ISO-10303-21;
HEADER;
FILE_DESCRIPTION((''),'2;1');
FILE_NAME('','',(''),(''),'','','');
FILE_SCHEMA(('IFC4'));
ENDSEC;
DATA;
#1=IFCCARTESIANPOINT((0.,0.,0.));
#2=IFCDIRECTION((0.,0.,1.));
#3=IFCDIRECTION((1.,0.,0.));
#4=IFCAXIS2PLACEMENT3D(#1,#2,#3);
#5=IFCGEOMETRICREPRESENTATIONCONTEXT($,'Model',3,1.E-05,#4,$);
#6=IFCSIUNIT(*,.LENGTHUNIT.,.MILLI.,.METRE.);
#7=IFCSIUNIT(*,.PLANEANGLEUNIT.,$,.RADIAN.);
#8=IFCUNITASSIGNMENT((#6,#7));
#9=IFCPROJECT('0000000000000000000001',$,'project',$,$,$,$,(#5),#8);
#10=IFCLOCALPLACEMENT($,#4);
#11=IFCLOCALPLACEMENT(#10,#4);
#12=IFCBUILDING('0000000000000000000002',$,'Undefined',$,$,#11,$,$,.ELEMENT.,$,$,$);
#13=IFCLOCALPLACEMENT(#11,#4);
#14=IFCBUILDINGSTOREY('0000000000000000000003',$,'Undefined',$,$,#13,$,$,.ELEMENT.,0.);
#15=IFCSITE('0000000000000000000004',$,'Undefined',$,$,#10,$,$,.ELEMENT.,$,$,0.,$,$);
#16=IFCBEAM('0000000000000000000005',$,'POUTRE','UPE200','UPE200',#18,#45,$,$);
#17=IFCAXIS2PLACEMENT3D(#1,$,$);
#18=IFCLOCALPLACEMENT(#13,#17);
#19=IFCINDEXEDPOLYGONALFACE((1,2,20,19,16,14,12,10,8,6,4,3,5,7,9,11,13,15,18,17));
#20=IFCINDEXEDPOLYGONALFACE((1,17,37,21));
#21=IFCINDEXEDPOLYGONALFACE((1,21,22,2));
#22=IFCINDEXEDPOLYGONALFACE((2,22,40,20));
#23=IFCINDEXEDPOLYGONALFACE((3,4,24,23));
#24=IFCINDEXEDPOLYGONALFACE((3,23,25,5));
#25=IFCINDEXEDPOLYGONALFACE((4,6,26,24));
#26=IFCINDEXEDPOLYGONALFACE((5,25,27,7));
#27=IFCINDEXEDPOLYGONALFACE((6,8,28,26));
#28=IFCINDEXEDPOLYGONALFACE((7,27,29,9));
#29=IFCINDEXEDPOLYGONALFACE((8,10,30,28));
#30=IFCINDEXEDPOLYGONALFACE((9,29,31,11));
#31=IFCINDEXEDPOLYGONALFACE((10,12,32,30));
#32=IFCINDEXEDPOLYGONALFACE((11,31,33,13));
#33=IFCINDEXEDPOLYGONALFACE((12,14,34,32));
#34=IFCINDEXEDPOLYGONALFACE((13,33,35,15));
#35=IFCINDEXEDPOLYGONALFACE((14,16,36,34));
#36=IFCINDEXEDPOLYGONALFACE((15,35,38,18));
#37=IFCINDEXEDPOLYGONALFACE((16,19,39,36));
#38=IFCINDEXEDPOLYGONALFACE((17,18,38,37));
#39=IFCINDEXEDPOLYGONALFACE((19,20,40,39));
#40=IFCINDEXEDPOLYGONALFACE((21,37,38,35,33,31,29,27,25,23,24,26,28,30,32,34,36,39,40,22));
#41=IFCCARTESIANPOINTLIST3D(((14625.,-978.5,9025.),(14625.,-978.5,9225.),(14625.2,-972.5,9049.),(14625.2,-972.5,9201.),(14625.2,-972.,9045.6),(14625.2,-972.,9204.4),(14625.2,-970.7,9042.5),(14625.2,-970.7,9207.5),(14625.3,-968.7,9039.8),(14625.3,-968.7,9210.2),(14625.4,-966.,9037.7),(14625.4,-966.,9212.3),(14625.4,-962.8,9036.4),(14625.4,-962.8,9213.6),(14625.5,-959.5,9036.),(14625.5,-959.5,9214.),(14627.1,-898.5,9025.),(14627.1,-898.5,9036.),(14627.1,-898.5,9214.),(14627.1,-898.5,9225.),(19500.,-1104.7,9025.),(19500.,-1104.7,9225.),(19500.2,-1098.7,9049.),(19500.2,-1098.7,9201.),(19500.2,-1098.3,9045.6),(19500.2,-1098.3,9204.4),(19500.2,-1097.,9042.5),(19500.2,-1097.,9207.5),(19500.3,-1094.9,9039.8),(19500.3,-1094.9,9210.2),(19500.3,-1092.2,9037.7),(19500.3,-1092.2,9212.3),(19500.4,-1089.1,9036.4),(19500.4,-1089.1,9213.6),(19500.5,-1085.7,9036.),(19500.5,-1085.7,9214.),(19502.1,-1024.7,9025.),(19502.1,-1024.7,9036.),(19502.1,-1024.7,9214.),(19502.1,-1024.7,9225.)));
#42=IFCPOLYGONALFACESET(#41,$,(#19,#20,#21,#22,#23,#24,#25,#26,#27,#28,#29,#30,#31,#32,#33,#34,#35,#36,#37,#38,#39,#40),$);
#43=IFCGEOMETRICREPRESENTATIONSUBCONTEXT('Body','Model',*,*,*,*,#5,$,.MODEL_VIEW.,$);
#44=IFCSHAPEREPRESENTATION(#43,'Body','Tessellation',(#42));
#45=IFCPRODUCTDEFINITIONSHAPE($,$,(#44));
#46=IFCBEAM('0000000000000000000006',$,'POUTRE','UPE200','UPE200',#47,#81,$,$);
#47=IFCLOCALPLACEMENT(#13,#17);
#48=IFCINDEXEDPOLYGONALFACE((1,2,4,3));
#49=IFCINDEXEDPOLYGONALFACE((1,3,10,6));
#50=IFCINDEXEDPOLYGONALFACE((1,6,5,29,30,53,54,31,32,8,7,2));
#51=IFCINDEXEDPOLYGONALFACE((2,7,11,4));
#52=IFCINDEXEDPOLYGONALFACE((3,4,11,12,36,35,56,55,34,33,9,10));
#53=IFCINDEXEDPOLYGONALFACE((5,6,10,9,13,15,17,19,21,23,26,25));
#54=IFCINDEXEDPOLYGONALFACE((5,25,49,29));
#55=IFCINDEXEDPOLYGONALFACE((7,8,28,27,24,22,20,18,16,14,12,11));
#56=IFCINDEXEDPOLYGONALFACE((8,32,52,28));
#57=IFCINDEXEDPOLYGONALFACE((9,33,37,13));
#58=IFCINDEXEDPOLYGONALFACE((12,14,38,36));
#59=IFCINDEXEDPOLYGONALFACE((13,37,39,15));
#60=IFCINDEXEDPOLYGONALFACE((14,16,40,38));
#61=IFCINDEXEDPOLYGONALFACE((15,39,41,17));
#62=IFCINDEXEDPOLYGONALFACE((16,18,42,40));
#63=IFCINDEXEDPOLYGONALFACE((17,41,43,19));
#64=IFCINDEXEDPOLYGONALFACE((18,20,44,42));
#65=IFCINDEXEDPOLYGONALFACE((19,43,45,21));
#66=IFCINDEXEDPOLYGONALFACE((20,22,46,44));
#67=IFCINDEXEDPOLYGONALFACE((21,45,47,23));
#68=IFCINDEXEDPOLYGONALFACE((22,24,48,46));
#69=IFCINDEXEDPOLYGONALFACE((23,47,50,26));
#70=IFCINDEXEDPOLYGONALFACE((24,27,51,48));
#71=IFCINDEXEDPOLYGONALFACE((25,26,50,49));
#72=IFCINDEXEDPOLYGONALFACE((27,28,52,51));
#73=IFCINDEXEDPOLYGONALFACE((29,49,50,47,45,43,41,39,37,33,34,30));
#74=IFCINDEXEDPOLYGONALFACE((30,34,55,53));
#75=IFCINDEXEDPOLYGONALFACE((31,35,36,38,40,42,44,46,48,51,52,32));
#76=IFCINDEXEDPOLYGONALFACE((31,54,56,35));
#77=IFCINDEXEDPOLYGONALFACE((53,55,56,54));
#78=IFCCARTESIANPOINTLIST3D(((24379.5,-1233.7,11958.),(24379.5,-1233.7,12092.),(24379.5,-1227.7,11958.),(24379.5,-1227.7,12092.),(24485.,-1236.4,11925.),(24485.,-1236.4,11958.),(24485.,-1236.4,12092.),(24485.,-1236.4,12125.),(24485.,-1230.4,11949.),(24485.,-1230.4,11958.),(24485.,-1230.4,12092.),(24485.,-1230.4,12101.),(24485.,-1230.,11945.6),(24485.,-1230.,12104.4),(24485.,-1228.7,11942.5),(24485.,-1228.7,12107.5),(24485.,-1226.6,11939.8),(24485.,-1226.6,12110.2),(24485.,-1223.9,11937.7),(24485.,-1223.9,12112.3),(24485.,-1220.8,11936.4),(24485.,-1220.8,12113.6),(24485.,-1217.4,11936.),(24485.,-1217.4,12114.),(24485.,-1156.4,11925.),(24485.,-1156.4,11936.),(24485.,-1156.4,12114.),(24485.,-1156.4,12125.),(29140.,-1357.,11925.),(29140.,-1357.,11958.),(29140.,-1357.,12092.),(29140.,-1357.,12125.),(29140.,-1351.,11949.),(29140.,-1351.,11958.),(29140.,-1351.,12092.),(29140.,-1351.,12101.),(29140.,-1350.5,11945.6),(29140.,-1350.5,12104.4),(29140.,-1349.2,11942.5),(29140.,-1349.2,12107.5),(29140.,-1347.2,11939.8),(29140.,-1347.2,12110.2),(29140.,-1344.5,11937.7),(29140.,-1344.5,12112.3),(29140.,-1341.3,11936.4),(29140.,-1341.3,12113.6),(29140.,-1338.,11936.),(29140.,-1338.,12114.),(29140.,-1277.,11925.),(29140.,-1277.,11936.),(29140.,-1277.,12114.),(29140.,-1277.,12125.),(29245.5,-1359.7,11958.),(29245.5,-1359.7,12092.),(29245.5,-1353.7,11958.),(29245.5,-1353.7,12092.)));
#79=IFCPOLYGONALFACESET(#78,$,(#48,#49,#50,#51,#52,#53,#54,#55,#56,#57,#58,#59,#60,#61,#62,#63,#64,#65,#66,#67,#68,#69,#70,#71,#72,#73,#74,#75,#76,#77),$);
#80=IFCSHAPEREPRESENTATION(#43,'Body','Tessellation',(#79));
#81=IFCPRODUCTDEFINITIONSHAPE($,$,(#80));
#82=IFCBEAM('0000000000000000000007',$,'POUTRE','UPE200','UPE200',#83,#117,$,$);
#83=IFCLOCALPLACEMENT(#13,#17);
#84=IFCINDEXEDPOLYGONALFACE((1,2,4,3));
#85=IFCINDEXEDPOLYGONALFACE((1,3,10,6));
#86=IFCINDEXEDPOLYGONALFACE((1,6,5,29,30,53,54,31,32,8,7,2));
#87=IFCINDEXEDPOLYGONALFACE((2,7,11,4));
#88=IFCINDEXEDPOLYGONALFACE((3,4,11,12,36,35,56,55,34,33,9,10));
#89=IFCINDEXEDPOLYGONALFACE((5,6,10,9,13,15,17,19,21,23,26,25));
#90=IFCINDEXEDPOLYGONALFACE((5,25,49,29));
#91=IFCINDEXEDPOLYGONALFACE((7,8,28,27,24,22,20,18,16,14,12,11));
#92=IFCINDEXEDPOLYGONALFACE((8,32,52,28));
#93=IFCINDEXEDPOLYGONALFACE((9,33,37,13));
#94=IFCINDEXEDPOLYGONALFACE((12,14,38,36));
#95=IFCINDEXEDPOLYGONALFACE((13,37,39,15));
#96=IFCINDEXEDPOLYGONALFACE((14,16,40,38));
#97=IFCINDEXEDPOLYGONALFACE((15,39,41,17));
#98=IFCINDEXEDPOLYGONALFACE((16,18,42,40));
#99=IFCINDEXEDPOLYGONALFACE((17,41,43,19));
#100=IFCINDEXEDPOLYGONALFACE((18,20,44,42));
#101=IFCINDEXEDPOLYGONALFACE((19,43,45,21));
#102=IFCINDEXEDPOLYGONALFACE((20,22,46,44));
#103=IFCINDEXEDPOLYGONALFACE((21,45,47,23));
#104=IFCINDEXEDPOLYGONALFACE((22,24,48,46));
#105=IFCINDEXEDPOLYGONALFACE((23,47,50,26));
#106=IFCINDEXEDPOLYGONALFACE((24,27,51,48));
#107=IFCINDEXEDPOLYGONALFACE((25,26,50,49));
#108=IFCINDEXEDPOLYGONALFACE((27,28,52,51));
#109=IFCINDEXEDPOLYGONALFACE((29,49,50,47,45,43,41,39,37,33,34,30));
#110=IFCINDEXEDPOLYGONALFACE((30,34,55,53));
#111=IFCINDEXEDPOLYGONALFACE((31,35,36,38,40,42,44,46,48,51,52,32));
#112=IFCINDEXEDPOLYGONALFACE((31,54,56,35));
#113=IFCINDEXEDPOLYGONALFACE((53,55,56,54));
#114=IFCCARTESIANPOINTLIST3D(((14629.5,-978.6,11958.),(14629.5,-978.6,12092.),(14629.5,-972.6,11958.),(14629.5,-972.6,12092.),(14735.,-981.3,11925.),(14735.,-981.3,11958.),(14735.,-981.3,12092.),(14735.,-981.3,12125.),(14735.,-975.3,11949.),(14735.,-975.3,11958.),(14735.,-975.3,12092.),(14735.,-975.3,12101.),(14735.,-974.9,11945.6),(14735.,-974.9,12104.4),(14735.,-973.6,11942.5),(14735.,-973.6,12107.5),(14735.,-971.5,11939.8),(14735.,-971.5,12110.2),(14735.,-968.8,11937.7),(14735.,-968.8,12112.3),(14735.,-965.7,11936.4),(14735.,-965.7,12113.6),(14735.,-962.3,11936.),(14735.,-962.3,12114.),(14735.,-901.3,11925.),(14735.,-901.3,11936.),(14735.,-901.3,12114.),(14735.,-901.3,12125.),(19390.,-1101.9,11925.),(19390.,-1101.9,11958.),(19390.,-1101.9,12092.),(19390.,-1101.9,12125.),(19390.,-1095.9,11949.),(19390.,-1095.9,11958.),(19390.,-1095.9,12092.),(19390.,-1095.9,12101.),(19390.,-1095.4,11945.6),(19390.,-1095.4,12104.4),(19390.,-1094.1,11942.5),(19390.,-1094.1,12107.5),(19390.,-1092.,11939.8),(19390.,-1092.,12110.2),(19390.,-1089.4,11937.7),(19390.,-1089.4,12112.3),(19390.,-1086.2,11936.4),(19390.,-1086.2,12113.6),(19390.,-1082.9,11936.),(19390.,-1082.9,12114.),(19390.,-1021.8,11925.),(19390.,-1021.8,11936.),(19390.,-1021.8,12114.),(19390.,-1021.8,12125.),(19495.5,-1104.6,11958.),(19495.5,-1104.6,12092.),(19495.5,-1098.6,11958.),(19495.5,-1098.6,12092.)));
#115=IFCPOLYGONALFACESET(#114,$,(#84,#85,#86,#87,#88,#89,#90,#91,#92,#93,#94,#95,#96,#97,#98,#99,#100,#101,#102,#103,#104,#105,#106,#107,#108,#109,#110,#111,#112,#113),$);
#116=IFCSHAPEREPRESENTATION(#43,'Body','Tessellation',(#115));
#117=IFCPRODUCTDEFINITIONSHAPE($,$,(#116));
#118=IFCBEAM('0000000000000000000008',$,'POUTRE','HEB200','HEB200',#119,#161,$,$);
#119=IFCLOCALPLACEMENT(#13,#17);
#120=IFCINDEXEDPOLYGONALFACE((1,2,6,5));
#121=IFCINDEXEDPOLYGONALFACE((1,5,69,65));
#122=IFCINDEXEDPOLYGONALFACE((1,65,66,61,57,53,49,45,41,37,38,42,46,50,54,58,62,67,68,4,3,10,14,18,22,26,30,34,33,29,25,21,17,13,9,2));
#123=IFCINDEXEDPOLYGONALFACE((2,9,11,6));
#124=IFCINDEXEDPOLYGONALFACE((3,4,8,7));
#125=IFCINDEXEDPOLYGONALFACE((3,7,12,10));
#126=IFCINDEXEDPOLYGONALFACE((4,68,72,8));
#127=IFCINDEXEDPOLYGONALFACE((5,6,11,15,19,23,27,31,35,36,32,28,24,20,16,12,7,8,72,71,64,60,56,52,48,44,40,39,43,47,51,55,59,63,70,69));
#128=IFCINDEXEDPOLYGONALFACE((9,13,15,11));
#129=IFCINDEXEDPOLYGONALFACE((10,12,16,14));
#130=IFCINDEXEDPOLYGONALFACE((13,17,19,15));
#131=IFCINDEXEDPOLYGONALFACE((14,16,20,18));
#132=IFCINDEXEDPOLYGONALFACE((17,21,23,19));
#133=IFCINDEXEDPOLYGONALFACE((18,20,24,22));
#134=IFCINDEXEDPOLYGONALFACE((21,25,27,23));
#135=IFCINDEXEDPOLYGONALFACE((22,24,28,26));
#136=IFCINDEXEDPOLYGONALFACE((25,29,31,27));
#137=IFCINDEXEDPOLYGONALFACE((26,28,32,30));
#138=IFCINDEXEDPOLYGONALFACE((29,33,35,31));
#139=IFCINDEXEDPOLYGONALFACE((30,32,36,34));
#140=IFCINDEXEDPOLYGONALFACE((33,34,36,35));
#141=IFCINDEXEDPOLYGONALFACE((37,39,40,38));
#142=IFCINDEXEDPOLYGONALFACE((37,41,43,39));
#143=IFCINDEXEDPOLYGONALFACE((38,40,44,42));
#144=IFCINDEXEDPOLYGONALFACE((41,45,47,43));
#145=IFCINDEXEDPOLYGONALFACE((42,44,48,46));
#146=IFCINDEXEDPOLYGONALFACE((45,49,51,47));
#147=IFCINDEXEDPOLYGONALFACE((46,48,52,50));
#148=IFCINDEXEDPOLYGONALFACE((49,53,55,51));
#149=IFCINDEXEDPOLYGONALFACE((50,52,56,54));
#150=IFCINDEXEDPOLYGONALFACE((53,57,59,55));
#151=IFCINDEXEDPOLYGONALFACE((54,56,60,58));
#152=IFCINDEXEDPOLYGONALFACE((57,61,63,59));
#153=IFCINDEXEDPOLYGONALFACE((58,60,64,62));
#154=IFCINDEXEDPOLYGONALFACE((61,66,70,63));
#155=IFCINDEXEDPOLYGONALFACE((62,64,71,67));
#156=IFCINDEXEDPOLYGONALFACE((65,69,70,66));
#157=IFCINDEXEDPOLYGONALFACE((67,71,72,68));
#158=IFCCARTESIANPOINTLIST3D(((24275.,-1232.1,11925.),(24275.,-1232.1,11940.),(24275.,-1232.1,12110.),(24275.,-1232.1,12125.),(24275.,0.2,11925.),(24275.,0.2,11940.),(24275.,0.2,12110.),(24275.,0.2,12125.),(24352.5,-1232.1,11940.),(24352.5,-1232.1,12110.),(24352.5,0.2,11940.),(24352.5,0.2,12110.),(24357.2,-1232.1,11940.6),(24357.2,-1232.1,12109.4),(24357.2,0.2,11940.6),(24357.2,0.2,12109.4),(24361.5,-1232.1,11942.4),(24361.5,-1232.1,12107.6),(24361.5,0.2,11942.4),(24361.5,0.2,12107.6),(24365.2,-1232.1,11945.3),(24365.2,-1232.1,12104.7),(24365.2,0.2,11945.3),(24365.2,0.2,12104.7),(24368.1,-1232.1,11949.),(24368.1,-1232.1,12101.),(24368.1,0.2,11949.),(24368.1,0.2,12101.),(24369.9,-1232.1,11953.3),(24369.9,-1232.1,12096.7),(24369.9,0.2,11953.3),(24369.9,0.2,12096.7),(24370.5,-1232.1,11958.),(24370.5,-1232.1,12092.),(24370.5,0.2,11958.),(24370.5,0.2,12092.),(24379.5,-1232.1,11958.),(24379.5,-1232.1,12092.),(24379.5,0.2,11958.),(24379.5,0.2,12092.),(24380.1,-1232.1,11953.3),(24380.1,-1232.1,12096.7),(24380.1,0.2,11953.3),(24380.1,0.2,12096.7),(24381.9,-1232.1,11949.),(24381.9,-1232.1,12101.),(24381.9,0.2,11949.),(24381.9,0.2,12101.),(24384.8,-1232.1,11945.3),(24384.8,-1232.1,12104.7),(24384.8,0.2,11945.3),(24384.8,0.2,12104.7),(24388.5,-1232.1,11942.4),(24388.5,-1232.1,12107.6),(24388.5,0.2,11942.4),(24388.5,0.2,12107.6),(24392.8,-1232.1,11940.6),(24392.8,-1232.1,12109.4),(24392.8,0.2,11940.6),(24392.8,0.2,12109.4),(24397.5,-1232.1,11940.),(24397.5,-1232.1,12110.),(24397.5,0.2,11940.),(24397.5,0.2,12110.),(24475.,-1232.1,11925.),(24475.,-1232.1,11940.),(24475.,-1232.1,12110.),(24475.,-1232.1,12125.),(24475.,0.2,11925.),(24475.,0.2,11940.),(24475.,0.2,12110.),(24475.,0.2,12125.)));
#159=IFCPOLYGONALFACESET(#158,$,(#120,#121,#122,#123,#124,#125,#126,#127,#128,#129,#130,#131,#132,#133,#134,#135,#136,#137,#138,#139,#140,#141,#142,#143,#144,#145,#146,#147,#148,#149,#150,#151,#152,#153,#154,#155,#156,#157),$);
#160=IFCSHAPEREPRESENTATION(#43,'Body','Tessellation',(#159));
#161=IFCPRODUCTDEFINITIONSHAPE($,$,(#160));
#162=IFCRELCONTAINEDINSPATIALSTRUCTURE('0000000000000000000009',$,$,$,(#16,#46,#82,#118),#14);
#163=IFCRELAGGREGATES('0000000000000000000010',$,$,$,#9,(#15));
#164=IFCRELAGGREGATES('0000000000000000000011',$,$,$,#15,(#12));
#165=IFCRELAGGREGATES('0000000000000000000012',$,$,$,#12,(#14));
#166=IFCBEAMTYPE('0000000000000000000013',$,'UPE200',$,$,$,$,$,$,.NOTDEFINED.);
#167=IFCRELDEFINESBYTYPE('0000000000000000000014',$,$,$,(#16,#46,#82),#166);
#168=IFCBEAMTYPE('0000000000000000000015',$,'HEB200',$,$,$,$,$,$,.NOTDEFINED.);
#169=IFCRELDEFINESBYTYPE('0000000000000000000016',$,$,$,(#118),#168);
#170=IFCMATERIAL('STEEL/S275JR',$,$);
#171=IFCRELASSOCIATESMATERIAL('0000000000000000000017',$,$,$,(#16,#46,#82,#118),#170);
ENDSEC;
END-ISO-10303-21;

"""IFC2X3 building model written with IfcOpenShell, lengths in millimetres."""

from ifc_helpers import new_model, si_unit, frame, origin_with_axes, origin_2d_with_axis, place, context, subcontext, project, spatial, rectangle, i_section, u_section, extrude, boolean, halfspace, material, type_object, element, save


model = new_model("IFC2X3")

# Units and contexts
model_context = context("Model", 3, precision=1e-05, world=origin_with_axes())
body_context = subcontext(model_context, "Body", "Model", "MODEL_VIEW")
ifc_project = project(units=[si_unit("LENGTHUNIT", "METRE", prefix="MILLI"), si_unit("PLANEANGLEUNIT", "RADIAN")], contexts=[model_context])

# Site, building, storey
site_placement = place(None, origin_with_axes())
site = spatial("IfcSite", under=ifc_project, at=site_placement, Name="Undefined", CompositionType="ELEMENT", RefElevation=0.0)
building_placement = place(site_placement, origin_with_axes())
building = spatial("IfcBuilding", under=site, at=building_placement, Name="Undefined", CompositionType="ELEMENT")
storey_placement = place(building_placement, origin_with_axes())
storey = spatial("IfcBuildingStorey", under=building, at=storey_placement, Name="Undefined", CompositionType="ELEMENT", Elevation=0.0)

# Shared definitions
ifc_material_1 = material(Name="STEEL/S275JR")

# Beams
beam_type_1 = type_object("IfcBeamType", Name="UPE200", PredefinedType="NOTDEFINED")
for number, where, z_axis, x_axis, name in (
    (1, (14626.0, -938.5, 9125.0), (0.0, 0.0, -1.0), (0.999665, -0.025886, 0.0), "POUTRE"),
):
    element("IfcBeam", number, at=place(storey_placement, frame(where, z_axis=z_axis, x_axis=x_axis)), inside=storey, type_object=beam_type_1, material=ifc_material_1, Name=name, Description="UPE200", ObjectType="UPE200", context=body_context, shape_type="SweptSolid", body=[
        extrude(u_section(Depth=200.0, FlangeWidth=80.0, WebThickness=6.0, FlangeThickness=11.0, FilletRadius=13.0, at=origin_2d_with_axis()), frame((4876.6, 0.0, 0.0), z_axis=(-1.0, 0.0, 0.0), x_axis=(0.0, -1.0, 0.0)), (0.0, 0.0, 1.0), 4876.6),
    ])
for number, where, z_axis, x_axis, name in (
    (2, (24376.0, -1193.6, 12025.0), (0.0, 0.0, -1.0), (0.999665, -0.025886, 0.0), "POUTRE"),
    (3, (14626.0, -938.5, 12025.0), (0.0, 0.0, -1.0), (0.999665, -0.025886, 0.0), "POUTRE"),
):
    element("IfcBeam", number, at=place(storey_placement, frame(where, z_axis=z_axis, x_axis=x_axis)), inside=storey, type_object=beam_type_1, material=ifc_material_1, Name=name, Description="UPE200", ObjectType="UPE200", context=body_context, shape_type="CSG", body=[
        boolean("DIFFERENCE", boolean("DIFFERENCE", boolean("DIFFERENCE", boolean("DIFFERENCE", boolean("DIFFERENCE", boolean("DIFFERENCE", extrude(u_section(Depth=200.0, FlangeWidth=80.0, WebThickness=6.0, FlangeThickness=11.0, FilletRadius=13.0, at=origin_2d_with_axis()), frame((4873.1, 0.0, 0.0), z_axis=(-1.0, 0.0, 0.0), x_axis=(0.0, -1.0, 0.0)), (0.0, 0.0, 1.0), 4871.7), extrude(rectangle(XDim=34.0, YDim=107.5, at=origin_2d_with_axis()), frame((4815.1, -162.9, 84.0), z_axis=(0.025886, 0.999665, 0.0), x_axis=(0.0, 0.0, 1.0)), (0.0, 0.0, 1.0), 205.3)), extrude(rectangle(XDim=34.0, YDim=107.5, at=origin_2d_with_axis()), frame((4815.1, -162.9, -84.0), z_axis=(0.025886, 0.999665, 0.0), x_axis=(0.0, 0.0, 1.0)), (0.0, 0.0, 1.0), 205.3)), extrude(rectangle(XDim=34.0, YDim=107.5, at=origin_2d_with_axis()), frame((59.5, 165.6, 84.0), z_axis=(-0.025886, -0.999665, 0.0), x_axis=(0.0, 0.0, 1.0)), (0.0, 0.0, 1.0), 208.0)), extrude(rectangle(XDim=34.0, YDim=107.5, at=origin_2d_with_axis()), frame((59.5, 165.6, -84.0), z_axis=(-0.025886, -0.999665, 0.0), x_axis=(0.0, 0.0, 1.0)), (0.0, 0.0, 1.0), 208.0)), halfspace(frame((4871.1, 0.0, 1000.0), z_axis=(-0.999665, 0.025886, 0.0), x_axis=(-0.025886, -0.999665, 0.0)), True)), halfspace(frame((3.5, 0.0, 1000.0), z_axis=(0.999665, -0.025886, 0.0), x_axis=(0.025886, 0.999665, 0.0)), True)),
    ])
beam_type_2 = type_object("IfcBeamType", Name="HEB200", PredefinedType="NOTDEFINED")
beam_1_placement = place(storey_placement, frame((24375.0, 0.2, 12025.0), z_axis=(0.0, 0.0, 1.0), x_axis=(0.0, -1.0, 0.0)))
element("IfcBeam", 4, at=beam_1_placement, inside=storey, type_object=beam_type_2, material=ifc_material_1, Name="POUTRE", Description="HEB200", ObjectType="HEB200", context=body_context, shape_type="SweptSolid", body=[
    extrude(i_section(OverallWidth=200.0, OverallDepth=200.0, WebThickness=9.0, FlangeThickness=15.0, FilletRadius=18.0, at=origin_2d_with_axis()), frame((1232.3, 0.0, 0.0), z_axis=(-1.0, 0.0, 0.0), x_axis=(0.0, -1.0, 0.0)), (0.0, 0.0, 1.0), 1232.3),
])

save(model, "model.ifc")
